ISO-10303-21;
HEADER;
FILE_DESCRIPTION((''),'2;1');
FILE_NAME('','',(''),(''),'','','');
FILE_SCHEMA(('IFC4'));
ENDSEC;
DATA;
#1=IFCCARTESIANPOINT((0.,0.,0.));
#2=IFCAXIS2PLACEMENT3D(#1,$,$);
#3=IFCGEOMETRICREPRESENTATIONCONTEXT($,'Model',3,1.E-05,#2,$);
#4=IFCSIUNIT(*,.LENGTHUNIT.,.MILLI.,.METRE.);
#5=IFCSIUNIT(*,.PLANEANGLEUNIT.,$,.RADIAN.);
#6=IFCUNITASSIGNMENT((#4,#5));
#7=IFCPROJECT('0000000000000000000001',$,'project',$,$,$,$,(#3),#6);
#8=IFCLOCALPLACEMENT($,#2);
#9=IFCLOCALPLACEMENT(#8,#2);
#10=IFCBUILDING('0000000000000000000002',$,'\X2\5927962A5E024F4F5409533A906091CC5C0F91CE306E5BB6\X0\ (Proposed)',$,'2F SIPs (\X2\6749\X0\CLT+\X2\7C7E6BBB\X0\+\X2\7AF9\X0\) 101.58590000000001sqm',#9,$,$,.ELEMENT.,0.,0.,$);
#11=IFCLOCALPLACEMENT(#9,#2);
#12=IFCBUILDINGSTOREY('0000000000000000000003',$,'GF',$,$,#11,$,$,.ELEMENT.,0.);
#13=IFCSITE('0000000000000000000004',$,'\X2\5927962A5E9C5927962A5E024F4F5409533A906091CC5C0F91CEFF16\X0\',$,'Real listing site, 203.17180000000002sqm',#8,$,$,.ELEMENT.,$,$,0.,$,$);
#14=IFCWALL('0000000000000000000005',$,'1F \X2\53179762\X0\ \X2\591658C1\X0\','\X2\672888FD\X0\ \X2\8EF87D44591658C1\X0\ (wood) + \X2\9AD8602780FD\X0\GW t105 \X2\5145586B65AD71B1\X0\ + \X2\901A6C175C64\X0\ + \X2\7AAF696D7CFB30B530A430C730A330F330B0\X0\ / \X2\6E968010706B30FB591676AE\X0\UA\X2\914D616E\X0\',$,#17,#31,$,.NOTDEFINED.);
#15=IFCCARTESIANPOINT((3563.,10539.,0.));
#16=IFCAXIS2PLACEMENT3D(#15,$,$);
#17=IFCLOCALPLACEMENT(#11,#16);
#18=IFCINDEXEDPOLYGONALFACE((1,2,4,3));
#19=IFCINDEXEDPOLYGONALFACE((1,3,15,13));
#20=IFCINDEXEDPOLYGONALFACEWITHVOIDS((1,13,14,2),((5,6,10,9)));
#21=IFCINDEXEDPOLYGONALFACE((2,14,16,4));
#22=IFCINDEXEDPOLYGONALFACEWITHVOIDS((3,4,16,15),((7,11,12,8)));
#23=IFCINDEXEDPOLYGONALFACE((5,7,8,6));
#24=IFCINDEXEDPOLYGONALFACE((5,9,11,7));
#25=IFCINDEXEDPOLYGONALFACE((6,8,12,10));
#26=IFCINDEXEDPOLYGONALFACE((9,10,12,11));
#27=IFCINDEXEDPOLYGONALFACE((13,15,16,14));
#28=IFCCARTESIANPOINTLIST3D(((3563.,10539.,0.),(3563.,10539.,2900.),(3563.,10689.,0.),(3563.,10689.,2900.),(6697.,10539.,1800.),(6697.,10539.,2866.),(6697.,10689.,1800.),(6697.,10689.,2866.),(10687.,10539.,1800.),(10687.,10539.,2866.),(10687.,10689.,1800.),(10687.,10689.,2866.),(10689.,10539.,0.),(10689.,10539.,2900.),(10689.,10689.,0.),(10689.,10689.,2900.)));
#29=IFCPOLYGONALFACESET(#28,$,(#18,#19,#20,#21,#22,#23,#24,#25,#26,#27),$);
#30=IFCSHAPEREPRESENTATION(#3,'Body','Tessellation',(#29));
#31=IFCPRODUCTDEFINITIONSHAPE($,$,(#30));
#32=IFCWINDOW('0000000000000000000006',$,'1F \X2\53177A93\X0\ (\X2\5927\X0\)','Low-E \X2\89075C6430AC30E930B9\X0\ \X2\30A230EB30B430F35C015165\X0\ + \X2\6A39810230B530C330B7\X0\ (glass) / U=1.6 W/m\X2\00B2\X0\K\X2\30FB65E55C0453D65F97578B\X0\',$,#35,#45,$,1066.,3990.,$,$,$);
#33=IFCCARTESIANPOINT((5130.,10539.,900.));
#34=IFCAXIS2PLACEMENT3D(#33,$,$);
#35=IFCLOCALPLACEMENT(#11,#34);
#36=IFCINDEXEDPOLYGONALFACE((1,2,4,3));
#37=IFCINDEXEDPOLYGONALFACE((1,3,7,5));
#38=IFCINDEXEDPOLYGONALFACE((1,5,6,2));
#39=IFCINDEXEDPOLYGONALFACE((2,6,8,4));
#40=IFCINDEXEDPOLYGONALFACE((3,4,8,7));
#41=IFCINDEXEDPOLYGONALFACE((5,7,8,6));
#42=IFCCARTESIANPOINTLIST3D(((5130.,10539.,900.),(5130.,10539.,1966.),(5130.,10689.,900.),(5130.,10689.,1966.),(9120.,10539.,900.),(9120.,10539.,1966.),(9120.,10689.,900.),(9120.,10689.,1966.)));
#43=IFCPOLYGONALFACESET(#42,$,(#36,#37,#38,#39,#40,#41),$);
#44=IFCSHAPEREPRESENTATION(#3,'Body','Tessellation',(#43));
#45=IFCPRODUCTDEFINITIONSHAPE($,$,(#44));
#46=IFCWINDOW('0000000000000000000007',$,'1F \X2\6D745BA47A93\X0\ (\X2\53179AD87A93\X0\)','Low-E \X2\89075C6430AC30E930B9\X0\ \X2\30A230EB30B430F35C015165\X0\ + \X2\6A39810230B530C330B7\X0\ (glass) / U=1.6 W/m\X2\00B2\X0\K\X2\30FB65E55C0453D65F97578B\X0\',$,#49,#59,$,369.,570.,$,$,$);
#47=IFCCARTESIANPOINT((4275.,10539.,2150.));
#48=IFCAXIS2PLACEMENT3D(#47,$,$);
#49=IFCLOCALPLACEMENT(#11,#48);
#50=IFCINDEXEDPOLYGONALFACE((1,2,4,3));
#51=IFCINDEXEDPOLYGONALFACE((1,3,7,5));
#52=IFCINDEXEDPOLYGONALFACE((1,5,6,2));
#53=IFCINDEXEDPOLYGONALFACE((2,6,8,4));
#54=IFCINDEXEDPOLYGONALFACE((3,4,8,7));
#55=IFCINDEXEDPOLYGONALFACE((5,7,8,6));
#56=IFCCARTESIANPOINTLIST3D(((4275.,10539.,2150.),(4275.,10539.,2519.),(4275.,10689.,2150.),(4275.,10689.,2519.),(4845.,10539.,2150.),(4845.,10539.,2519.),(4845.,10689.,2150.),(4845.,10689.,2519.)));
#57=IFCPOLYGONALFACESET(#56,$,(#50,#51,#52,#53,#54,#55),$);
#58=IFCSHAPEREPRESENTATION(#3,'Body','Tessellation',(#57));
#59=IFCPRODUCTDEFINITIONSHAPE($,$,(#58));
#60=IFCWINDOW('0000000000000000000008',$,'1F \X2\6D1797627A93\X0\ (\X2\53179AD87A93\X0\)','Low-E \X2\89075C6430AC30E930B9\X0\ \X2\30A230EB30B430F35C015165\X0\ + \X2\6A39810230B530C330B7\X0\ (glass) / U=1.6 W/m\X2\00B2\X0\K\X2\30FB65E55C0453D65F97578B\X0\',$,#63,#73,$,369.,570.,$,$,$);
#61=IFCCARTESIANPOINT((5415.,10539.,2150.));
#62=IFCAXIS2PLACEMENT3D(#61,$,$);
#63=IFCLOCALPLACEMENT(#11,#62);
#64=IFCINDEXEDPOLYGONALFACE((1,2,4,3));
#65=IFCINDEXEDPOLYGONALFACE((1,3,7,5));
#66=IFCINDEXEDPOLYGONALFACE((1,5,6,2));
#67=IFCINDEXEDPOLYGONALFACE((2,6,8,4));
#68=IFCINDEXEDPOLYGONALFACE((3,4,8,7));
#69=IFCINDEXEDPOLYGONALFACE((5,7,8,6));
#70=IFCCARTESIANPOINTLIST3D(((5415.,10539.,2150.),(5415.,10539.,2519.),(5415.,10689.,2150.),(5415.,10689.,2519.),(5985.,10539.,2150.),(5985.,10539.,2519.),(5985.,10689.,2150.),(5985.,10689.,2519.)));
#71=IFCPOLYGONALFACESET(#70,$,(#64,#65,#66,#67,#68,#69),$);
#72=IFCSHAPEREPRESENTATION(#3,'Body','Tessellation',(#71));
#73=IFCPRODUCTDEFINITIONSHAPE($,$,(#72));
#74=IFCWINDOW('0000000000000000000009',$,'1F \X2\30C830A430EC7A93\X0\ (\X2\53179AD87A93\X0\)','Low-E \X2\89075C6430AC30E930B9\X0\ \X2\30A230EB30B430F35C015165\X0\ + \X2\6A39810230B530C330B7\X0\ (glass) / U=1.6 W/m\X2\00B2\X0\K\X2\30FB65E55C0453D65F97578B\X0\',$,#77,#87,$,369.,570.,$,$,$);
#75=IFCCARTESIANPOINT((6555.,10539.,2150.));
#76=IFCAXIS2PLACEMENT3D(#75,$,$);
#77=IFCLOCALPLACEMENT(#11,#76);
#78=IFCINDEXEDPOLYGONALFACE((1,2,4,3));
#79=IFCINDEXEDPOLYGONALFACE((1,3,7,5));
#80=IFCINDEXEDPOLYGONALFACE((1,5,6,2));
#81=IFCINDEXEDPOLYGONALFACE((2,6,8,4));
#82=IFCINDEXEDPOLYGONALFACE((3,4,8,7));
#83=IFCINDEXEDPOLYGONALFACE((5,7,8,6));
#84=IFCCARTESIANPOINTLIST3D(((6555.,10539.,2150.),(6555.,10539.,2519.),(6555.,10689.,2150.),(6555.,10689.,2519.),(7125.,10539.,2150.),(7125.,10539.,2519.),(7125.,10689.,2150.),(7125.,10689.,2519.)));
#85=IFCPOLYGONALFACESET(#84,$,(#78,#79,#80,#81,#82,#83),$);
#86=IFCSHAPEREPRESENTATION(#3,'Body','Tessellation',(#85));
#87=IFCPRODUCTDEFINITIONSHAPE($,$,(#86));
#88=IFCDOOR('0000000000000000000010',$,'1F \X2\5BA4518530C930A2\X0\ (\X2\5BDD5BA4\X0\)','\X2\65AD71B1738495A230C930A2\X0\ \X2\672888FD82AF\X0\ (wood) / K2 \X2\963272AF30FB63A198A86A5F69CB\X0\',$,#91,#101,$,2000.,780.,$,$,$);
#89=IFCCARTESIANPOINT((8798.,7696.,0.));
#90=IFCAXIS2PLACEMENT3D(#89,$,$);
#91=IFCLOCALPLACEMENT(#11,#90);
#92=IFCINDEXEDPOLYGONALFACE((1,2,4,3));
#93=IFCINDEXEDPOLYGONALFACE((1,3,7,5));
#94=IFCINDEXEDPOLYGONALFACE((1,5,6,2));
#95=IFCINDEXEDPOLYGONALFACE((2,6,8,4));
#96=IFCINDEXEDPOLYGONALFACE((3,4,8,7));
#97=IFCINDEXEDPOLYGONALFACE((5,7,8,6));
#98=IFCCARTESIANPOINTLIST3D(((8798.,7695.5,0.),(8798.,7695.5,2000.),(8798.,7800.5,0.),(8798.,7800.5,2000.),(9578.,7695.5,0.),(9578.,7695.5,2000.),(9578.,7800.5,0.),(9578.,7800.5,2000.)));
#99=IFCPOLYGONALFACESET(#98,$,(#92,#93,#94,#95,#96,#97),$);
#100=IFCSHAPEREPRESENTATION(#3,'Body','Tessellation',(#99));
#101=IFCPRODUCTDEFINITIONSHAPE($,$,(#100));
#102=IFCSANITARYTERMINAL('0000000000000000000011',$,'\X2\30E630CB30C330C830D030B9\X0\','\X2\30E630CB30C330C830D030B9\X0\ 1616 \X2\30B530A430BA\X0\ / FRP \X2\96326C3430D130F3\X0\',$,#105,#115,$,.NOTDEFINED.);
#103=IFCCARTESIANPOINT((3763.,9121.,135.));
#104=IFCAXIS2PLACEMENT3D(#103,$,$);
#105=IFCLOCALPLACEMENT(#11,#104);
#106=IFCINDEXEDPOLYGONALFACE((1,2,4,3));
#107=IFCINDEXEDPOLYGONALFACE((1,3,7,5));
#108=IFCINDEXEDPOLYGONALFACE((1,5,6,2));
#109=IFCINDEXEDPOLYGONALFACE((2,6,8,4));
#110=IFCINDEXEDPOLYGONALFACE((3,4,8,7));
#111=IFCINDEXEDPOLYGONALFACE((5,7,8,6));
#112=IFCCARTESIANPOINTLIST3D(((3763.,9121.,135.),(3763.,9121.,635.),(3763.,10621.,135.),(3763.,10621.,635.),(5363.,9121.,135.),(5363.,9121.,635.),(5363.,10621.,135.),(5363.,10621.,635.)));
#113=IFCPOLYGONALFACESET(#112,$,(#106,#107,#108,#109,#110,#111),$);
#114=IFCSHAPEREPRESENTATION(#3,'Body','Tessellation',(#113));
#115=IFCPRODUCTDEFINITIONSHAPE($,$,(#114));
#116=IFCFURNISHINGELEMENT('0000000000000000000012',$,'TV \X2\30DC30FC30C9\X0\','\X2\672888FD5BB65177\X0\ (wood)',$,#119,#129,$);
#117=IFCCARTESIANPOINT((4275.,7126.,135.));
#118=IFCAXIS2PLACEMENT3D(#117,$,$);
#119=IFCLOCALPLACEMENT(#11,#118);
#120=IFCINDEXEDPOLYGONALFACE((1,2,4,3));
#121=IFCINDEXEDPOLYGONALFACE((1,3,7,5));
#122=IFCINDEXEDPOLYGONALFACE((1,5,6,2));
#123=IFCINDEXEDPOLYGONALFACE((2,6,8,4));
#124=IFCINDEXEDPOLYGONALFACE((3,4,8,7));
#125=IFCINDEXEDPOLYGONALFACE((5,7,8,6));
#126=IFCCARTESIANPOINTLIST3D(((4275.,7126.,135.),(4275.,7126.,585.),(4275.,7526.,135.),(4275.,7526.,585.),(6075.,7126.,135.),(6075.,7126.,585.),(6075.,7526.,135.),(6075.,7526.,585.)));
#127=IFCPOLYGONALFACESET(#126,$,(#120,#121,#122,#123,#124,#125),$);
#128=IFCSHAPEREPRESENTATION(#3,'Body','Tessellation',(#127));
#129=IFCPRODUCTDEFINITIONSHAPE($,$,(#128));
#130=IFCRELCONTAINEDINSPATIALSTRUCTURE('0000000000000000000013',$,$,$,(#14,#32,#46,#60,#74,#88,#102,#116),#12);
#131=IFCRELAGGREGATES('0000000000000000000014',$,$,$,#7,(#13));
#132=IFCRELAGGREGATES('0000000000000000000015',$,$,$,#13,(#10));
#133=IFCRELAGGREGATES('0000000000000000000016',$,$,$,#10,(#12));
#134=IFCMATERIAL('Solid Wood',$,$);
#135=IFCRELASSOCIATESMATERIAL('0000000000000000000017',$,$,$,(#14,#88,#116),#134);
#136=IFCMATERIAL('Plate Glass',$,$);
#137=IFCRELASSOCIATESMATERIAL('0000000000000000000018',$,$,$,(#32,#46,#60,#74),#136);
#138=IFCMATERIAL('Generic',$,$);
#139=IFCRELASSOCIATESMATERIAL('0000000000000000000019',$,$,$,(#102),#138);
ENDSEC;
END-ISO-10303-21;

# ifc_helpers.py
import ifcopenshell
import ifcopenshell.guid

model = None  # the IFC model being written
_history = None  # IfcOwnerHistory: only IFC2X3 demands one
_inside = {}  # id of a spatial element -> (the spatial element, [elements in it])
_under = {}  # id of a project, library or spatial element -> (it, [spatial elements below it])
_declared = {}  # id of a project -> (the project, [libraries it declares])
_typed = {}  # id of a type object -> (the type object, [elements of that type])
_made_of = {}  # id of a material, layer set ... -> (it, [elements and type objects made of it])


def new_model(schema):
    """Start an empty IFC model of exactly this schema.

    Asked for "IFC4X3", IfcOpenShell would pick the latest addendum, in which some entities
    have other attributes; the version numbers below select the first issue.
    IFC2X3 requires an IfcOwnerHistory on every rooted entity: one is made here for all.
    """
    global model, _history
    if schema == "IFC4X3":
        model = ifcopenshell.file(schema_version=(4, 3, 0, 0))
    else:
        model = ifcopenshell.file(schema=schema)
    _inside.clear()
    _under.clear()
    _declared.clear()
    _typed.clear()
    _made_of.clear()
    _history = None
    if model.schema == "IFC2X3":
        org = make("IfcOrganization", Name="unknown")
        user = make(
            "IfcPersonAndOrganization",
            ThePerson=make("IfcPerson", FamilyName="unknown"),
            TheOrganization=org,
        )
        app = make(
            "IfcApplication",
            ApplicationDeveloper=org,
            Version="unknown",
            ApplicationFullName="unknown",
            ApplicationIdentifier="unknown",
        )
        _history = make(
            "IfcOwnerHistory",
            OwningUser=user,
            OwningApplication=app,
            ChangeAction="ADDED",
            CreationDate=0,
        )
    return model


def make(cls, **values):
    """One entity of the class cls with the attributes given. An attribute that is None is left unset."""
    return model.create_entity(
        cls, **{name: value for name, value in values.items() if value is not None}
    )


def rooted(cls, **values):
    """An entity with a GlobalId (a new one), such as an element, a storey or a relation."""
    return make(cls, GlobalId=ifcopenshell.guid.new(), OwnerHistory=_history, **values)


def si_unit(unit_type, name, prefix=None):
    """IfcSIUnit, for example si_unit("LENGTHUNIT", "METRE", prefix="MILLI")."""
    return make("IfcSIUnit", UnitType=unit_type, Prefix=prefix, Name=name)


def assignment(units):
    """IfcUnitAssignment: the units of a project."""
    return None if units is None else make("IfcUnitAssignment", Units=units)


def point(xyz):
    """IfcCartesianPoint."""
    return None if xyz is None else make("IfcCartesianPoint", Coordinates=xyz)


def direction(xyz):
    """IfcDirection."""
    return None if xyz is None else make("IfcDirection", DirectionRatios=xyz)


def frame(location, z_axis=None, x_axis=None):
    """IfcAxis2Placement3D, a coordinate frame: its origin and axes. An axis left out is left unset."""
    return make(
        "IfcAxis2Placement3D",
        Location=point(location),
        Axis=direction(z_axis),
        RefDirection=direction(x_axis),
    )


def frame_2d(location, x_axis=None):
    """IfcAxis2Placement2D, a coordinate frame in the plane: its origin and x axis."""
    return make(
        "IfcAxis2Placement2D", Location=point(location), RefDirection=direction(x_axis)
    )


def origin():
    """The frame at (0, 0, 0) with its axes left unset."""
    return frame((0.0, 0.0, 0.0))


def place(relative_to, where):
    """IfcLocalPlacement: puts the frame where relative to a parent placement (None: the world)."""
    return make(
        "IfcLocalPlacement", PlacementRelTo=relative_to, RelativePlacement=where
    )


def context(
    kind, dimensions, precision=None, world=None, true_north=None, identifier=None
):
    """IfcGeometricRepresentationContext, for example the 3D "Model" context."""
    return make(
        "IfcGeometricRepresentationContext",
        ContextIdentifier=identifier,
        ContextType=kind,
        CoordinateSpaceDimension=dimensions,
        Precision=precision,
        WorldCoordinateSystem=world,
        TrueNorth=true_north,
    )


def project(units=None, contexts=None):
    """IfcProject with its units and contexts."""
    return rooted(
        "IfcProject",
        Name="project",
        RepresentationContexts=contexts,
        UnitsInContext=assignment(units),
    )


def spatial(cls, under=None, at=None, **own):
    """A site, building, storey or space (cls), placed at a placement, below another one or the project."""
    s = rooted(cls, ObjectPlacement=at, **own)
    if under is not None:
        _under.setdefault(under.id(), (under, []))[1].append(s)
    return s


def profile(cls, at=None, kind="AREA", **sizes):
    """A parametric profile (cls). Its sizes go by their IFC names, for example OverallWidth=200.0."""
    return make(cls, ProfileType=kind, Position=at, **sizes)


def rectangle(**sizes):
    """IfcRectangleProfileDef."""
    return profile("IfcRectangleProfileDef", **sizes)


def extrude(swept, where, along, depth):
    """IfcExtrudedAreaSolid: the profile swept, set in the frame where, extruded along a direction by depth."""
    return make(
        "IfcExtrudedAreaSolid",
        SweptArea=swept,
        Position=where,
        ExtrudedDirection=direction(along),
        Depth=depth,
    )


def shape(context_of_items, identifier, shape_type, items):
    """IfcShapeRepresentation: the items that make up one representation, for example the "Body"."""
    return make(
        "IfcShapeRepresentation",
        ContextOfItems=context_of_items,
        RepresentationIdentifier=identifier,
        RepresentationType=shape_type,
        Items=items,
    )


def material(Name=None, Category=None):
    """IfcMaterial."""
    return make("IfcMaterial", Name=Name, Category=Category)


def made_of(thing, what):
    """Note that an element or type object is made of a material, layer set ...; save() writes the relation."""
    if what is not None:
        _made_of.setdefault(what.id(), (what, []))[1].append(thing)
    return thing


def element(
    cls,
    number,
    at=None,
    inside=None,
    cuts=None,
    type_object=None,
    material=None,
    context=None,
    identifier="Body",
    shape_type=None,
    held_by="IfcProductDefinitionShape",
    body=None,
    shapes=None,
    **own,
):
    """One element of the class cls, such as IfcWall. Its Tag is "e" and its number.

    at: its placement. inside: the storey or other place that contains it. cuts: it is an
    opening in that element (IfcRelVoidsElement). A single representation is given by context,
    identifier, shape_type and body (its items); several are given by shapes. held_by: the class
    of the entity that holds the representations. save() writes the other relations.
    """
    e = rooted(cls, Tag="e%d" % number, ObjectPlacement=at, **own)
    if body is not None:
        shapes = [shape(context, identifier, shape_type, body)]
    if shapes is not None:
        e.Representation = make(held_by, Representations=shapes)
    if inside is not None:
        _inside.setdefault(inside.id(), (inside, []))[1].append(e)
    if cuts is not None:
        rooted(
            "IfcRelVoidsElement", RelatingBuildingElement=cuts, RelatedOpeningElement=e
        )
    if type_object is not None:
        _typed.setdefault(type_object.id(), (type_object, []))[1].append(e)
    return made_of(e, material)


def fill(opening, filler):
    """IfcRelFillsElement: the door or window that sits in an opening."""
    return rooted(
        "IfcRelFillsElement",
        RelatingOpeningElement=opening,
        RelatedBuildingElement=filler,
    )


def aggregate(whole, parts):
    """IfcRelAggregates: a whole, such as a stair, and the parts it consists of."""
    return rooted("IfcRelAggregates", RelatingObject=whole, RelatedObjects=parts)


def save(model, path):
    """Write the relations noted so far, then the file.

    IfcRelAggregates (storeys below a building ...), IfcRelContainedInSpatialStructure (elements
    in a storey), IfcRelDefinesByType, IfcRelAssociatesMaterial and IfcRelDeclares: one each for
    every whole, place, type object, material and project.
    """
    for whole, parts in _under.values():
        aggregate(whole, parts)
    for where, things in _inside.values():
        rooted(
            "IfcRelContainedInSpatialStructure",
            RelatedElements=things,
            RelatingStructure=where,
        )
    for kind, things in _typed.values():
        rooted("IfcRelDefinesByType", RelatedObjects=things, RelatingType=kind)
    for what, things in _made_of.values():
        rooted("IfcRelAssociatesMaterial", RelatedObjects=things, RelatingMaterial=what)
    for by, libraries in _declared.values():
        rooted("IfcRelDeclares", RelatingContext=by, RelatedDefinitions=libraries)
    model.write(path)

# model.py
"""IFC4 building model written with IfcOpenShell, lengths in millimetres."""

from ifc_helpers import new_model, si_unit, frame, frame_2d, origin, place, context, project, spatial, rectangle, extrude, material, element, fill, save


model = new_model("IFC4")

# Units and contexts
model_context = context("Model", 3, precision=1e-05, world=origin())
ifc_project = project(units=[si_unit("LENGTHUNIT", "METRE", prefix="MILLI"), si_unit("PLANEANGLEUNIT", "RADIAN")], contexts=[model_context])

# Site, building, storey
site_placement = place(None, origin())
site = spatial("IfcSite", under=ifc_project, at=site_placement, Name="大阪府大阪市住吉区遠里小野６", ObjectType="Real listing site, 203.17180000000002sqm", CompositionType="ELEMENT", RefElevation=0.0)
building_placement = place(site_placement, origin())
building = spatial("IfcBuilding", under=site, at=building_placement, Name="大阪市住吉区遠里小野の家 (Proposed)", ObjectType="2F SIPs (杉CLT+籾殻+竹) 101.58590000000001sqm", CompositionType="ELEMENT", ElevationOfRefHeight=0.0, ElevationOfTerrain=0.0)
storey_placement = place(building_placement, origin())
storey = spatial("IfcBuildingStorey", under=building, at=storey_placement, Name="GF", CompositionType="ELEMENT", Elevation=0.0)

# Wall, openings, windows
ifc_material_1 = material(Name="Solid Wood")
wall_1_placement = place(storey_placement, frame((3563.0, 10539.0, 0.0)))
wall_1 = element("IfcWall", 1, at=wall_1_placement, inside=storey, material=ifc_material_1, Name="1F 北面 外壁", Description="木製 軸組外壁 (wood) + 高性能GW t105 充填断熱 + 通気層 + 窯業系サイディング / 準耐火・外皮UA配慮", PredefinedType="NOTDEFINED", context=model_context, shape_type="SweptSolid", body=[
    extrude(rectangle(XDim=7126.0, YDim=150.0, at=frame_2d((3563.0, 75.0))), frame((3563.0, 10539.0, 0.0)), (0.0, 0.0, 1.0), 2900.0),
])
opening_1_placement = place(storey_placement, frame((5130.0, 10539.0, 900.0)))
opening_1 = element("IfcOpeningElement", 2, at=opening_1_placement, cuts=wall_1, PredefinedType="NOTDEFINED", context=model_context, shape_type="SweptSolid", body=[
    extrude(rectangle(XDim=3990.0, YDim=150.0, at=frame_2d((1995.0, 75.0))), frame((5130.0, 10539.0, 900.0)), (0.0, 0.0, 1.0), 1066.0),
])
opening_2_placement = place(storey_placement, frame((4275.0, 10539.0, 2150.0)))
opening_2 = element("IfcOpeningElement", 3, at=opening_2_placement, cuts=wall_1, PredefinedType="NOTDEFINED", context=model_context, shape_type="SweptSolid", body=[
    extrude(rectangle(XDim=570.0, YDim=150.0, at=frame_2d((285.0, 75.0))), frame((4275.0, 10539.0, 2150.0)), (0.0, 0.0, 1.0), 369.0),
])
opening_3_placement = place(storey_placement, frame((5415.0, 10539.0, 2150.0)))
opening_3 = element("IfcOpeningElement", 4, at=opening_3_placement, cuts=wall_1, PredefinedType="NOTDEFINED", context=model_context, shape_type="SweptSolid", body=[
    extrude(rectangle(XDim=570.0, YDim=150.0, at=frame_2d((285.0, 75.0))), frame((5415.0, 10539.0, 2150.0)), (0.0, 0.0, 1.0), 369.0),
])
opening_4_placement = place(storey_placement, frame((6555.0, 10539.0, 2150.0)))
opening_4 = element("IfcOpeningElement", 5, at=opening_4_placement, cuts=wall_1, PredefinedType="NOTDEFINED", context=model_context, shape_type="SweptSolid", body=[
    extrude(rectangle(XDim=570.0, YDim=150.0, at=frame_2d((285.0, 75.0))), frame((6555.0, 10539.0, 2150.0)), (0.0, 0.0, 1.0), 369.0),
])
ifc_material_2 = material(Name="Plate Glass")
window_1_placement = place(storey_placement, frame((5130.0, 10539.0, 900.0)))
window_1 = element("IfcWindow", 6, at=window_1_placement, inside=storey, material=ifc_material_2, Name="1F 北窓 (大)", Description="Low-E 複層ガラス アルゴン封入 + 樹脂サッシ (glass) / U=1.6 W/m²K・日射取得型", OverallHeight=1066.0, OverallWidth=3990.0, context=model_context, shape_type="SweptSolid", body=[
    extrude(rectangle(XDim=3990.0, YDim=150.0, at=frame_2d((1995.0, 75.0))), frame((5130.0, 10539.0, 900.0)), (0.0, 0.0, 1.0), 1066.0),
])
fill(opening_1, window_1)
window_2_placement = place(storey_placement, frame((4275.0, 10539.0, 2150.0)))
window_2 = element("IfcWindow", 7, at=window_2_placement, inside=storey, material=ifc_material_2, Name="1F 浴室窓 (北高窓)", Description="Low-E 複層ガラス アルゴン封入 + 樹脂サッシ (glass) / U=1.6 W/m²K・日射取得型", OverallHeight=369.0, OverallWidth=570.0, context=model_context, shape_type="SweptSolid", body=[
    extrude(rectangle(XDim=570.0, YDim=150.0, at=frame_2d((285.0, 75.0))), frame((4275.0, 10539.0, 2150.0)), (0.0, 0.0, 1.0), 369.0),
])
fill(opening_2, window_2)
window_3_placement = place(storey_placement, frame((5415.0, 10539.0, 2150.0)))
window_3 = element("IfcWindow", 8, at=window_3_placement, inside=storey, material=ifc_material_2, Name="1F 洗面窓 (北高窓)", Description="Low-E 複層ガラス アルゴン封入 + 樹脂サッシ (glass) / U=1.6 W/m²K・日射取得型", OverallHeight=369.0, OverallWidth=570.0, context=model_context, shape_type="SweptSolid", body=[
    extrude(rectangle(XDim=570.0, YDim=150.0, at=frame_2d((285.0, 75.0))), frame((5415.0, 10539.0, 2150.0)), (0.0, 0.0, 1.0), 369.0),
])
fill(opening_3, window_3)
window_4_placement = place(storey_placement, frame((6555.0, 10539.0, 2150.0)))
window_4 = element("IfcWindow", 9, at=window_4_placement, inside=storey, material=ifc_material_2, Name="1F トイレ窓 (北高窓)", Description="Low-E 複層ガラス アルゴン封入 + 樹脂サッシ (glass) / U=1.6 W/m²K・日射取得型", OverallHeight=369.0, OverallWidth=570.0, context=model_context, shape_type="SweptSolid", body=[
    extrude(rectangle(XDim=570.0, YDim=150.0, at=frame_2d((285.0, 75.0))), frame((6555.0, 10539.0, 2150.0)), (0.0, 0.0, 1.0), 369.0),
])
fill(opening_4, window_4)

# Door
door_1_placement = place(storey_placement, frame((8798.0, 7696.0, 0.0)))
element("IfcDoor", 10, at=door_1_placement, inside=storey, material=ifc_material_1, Name="1F 室内ドア (寝室)", Description="断熱玄関ドア 木製芯 (wood) / K2 防犯・採風機構", OverallHeight=2000.0, OverallWidth=780.0, context=model_context, shape_type="SweptSolid", body=[
    extrude(rectangle(XDim=780.0, YDim=105.0, at=frame_2d((390.0, 52.0))), frame((8798.0, 7696.0, 0.0)), (0.0, 0.0, 1.0), 2000.0),
])

# Sanitary terminal
ifc_material_3 = material(Name="Generic")
sanitary_terminal_placement = place(storey_placement, frame((3763.0, 9121.0, 135.0)))
element("IfcSanitaryTerminal", 11, at=sanitary_terminal_placement, inside=storey, material=ifc_material_3, Name="ユニットバス", Description="ユニットバス 1616 サイズ / FRP 防水パン", PredefinedType="NOTDEFINED", context=model_context, shape_type="SweptSolid", body=[
    extrude(rectangle(XDim=1600.0, YDim=1500.0, at=frame_2d((800.0, 750.0))), frame((3763.0, 9121.0, 135.0)), (0.0, 0.0, 1.0), 500.0),
])

# Furnishing element
furnishing_placement = place(storey_placement, frame((4275.0, 7126.0, 135.0)))
element("IfcFurnishingElement", 12, at=furnishing_placement, inside=storey, material=ifc_material_1, Name="TV ボード", Description="木製家具 (wood)", context=model_context, shape_type="SweptSolid", body=[
    extrude(rectangle(XDim=1800.0, YDim=400.0, at=frame_2d((900.0, 200.0))), frame((4275.0, 7126.0, 135.0)), (0.0, 0.0, 1.0), 450.0),
])

save(model, "model.ifc")
